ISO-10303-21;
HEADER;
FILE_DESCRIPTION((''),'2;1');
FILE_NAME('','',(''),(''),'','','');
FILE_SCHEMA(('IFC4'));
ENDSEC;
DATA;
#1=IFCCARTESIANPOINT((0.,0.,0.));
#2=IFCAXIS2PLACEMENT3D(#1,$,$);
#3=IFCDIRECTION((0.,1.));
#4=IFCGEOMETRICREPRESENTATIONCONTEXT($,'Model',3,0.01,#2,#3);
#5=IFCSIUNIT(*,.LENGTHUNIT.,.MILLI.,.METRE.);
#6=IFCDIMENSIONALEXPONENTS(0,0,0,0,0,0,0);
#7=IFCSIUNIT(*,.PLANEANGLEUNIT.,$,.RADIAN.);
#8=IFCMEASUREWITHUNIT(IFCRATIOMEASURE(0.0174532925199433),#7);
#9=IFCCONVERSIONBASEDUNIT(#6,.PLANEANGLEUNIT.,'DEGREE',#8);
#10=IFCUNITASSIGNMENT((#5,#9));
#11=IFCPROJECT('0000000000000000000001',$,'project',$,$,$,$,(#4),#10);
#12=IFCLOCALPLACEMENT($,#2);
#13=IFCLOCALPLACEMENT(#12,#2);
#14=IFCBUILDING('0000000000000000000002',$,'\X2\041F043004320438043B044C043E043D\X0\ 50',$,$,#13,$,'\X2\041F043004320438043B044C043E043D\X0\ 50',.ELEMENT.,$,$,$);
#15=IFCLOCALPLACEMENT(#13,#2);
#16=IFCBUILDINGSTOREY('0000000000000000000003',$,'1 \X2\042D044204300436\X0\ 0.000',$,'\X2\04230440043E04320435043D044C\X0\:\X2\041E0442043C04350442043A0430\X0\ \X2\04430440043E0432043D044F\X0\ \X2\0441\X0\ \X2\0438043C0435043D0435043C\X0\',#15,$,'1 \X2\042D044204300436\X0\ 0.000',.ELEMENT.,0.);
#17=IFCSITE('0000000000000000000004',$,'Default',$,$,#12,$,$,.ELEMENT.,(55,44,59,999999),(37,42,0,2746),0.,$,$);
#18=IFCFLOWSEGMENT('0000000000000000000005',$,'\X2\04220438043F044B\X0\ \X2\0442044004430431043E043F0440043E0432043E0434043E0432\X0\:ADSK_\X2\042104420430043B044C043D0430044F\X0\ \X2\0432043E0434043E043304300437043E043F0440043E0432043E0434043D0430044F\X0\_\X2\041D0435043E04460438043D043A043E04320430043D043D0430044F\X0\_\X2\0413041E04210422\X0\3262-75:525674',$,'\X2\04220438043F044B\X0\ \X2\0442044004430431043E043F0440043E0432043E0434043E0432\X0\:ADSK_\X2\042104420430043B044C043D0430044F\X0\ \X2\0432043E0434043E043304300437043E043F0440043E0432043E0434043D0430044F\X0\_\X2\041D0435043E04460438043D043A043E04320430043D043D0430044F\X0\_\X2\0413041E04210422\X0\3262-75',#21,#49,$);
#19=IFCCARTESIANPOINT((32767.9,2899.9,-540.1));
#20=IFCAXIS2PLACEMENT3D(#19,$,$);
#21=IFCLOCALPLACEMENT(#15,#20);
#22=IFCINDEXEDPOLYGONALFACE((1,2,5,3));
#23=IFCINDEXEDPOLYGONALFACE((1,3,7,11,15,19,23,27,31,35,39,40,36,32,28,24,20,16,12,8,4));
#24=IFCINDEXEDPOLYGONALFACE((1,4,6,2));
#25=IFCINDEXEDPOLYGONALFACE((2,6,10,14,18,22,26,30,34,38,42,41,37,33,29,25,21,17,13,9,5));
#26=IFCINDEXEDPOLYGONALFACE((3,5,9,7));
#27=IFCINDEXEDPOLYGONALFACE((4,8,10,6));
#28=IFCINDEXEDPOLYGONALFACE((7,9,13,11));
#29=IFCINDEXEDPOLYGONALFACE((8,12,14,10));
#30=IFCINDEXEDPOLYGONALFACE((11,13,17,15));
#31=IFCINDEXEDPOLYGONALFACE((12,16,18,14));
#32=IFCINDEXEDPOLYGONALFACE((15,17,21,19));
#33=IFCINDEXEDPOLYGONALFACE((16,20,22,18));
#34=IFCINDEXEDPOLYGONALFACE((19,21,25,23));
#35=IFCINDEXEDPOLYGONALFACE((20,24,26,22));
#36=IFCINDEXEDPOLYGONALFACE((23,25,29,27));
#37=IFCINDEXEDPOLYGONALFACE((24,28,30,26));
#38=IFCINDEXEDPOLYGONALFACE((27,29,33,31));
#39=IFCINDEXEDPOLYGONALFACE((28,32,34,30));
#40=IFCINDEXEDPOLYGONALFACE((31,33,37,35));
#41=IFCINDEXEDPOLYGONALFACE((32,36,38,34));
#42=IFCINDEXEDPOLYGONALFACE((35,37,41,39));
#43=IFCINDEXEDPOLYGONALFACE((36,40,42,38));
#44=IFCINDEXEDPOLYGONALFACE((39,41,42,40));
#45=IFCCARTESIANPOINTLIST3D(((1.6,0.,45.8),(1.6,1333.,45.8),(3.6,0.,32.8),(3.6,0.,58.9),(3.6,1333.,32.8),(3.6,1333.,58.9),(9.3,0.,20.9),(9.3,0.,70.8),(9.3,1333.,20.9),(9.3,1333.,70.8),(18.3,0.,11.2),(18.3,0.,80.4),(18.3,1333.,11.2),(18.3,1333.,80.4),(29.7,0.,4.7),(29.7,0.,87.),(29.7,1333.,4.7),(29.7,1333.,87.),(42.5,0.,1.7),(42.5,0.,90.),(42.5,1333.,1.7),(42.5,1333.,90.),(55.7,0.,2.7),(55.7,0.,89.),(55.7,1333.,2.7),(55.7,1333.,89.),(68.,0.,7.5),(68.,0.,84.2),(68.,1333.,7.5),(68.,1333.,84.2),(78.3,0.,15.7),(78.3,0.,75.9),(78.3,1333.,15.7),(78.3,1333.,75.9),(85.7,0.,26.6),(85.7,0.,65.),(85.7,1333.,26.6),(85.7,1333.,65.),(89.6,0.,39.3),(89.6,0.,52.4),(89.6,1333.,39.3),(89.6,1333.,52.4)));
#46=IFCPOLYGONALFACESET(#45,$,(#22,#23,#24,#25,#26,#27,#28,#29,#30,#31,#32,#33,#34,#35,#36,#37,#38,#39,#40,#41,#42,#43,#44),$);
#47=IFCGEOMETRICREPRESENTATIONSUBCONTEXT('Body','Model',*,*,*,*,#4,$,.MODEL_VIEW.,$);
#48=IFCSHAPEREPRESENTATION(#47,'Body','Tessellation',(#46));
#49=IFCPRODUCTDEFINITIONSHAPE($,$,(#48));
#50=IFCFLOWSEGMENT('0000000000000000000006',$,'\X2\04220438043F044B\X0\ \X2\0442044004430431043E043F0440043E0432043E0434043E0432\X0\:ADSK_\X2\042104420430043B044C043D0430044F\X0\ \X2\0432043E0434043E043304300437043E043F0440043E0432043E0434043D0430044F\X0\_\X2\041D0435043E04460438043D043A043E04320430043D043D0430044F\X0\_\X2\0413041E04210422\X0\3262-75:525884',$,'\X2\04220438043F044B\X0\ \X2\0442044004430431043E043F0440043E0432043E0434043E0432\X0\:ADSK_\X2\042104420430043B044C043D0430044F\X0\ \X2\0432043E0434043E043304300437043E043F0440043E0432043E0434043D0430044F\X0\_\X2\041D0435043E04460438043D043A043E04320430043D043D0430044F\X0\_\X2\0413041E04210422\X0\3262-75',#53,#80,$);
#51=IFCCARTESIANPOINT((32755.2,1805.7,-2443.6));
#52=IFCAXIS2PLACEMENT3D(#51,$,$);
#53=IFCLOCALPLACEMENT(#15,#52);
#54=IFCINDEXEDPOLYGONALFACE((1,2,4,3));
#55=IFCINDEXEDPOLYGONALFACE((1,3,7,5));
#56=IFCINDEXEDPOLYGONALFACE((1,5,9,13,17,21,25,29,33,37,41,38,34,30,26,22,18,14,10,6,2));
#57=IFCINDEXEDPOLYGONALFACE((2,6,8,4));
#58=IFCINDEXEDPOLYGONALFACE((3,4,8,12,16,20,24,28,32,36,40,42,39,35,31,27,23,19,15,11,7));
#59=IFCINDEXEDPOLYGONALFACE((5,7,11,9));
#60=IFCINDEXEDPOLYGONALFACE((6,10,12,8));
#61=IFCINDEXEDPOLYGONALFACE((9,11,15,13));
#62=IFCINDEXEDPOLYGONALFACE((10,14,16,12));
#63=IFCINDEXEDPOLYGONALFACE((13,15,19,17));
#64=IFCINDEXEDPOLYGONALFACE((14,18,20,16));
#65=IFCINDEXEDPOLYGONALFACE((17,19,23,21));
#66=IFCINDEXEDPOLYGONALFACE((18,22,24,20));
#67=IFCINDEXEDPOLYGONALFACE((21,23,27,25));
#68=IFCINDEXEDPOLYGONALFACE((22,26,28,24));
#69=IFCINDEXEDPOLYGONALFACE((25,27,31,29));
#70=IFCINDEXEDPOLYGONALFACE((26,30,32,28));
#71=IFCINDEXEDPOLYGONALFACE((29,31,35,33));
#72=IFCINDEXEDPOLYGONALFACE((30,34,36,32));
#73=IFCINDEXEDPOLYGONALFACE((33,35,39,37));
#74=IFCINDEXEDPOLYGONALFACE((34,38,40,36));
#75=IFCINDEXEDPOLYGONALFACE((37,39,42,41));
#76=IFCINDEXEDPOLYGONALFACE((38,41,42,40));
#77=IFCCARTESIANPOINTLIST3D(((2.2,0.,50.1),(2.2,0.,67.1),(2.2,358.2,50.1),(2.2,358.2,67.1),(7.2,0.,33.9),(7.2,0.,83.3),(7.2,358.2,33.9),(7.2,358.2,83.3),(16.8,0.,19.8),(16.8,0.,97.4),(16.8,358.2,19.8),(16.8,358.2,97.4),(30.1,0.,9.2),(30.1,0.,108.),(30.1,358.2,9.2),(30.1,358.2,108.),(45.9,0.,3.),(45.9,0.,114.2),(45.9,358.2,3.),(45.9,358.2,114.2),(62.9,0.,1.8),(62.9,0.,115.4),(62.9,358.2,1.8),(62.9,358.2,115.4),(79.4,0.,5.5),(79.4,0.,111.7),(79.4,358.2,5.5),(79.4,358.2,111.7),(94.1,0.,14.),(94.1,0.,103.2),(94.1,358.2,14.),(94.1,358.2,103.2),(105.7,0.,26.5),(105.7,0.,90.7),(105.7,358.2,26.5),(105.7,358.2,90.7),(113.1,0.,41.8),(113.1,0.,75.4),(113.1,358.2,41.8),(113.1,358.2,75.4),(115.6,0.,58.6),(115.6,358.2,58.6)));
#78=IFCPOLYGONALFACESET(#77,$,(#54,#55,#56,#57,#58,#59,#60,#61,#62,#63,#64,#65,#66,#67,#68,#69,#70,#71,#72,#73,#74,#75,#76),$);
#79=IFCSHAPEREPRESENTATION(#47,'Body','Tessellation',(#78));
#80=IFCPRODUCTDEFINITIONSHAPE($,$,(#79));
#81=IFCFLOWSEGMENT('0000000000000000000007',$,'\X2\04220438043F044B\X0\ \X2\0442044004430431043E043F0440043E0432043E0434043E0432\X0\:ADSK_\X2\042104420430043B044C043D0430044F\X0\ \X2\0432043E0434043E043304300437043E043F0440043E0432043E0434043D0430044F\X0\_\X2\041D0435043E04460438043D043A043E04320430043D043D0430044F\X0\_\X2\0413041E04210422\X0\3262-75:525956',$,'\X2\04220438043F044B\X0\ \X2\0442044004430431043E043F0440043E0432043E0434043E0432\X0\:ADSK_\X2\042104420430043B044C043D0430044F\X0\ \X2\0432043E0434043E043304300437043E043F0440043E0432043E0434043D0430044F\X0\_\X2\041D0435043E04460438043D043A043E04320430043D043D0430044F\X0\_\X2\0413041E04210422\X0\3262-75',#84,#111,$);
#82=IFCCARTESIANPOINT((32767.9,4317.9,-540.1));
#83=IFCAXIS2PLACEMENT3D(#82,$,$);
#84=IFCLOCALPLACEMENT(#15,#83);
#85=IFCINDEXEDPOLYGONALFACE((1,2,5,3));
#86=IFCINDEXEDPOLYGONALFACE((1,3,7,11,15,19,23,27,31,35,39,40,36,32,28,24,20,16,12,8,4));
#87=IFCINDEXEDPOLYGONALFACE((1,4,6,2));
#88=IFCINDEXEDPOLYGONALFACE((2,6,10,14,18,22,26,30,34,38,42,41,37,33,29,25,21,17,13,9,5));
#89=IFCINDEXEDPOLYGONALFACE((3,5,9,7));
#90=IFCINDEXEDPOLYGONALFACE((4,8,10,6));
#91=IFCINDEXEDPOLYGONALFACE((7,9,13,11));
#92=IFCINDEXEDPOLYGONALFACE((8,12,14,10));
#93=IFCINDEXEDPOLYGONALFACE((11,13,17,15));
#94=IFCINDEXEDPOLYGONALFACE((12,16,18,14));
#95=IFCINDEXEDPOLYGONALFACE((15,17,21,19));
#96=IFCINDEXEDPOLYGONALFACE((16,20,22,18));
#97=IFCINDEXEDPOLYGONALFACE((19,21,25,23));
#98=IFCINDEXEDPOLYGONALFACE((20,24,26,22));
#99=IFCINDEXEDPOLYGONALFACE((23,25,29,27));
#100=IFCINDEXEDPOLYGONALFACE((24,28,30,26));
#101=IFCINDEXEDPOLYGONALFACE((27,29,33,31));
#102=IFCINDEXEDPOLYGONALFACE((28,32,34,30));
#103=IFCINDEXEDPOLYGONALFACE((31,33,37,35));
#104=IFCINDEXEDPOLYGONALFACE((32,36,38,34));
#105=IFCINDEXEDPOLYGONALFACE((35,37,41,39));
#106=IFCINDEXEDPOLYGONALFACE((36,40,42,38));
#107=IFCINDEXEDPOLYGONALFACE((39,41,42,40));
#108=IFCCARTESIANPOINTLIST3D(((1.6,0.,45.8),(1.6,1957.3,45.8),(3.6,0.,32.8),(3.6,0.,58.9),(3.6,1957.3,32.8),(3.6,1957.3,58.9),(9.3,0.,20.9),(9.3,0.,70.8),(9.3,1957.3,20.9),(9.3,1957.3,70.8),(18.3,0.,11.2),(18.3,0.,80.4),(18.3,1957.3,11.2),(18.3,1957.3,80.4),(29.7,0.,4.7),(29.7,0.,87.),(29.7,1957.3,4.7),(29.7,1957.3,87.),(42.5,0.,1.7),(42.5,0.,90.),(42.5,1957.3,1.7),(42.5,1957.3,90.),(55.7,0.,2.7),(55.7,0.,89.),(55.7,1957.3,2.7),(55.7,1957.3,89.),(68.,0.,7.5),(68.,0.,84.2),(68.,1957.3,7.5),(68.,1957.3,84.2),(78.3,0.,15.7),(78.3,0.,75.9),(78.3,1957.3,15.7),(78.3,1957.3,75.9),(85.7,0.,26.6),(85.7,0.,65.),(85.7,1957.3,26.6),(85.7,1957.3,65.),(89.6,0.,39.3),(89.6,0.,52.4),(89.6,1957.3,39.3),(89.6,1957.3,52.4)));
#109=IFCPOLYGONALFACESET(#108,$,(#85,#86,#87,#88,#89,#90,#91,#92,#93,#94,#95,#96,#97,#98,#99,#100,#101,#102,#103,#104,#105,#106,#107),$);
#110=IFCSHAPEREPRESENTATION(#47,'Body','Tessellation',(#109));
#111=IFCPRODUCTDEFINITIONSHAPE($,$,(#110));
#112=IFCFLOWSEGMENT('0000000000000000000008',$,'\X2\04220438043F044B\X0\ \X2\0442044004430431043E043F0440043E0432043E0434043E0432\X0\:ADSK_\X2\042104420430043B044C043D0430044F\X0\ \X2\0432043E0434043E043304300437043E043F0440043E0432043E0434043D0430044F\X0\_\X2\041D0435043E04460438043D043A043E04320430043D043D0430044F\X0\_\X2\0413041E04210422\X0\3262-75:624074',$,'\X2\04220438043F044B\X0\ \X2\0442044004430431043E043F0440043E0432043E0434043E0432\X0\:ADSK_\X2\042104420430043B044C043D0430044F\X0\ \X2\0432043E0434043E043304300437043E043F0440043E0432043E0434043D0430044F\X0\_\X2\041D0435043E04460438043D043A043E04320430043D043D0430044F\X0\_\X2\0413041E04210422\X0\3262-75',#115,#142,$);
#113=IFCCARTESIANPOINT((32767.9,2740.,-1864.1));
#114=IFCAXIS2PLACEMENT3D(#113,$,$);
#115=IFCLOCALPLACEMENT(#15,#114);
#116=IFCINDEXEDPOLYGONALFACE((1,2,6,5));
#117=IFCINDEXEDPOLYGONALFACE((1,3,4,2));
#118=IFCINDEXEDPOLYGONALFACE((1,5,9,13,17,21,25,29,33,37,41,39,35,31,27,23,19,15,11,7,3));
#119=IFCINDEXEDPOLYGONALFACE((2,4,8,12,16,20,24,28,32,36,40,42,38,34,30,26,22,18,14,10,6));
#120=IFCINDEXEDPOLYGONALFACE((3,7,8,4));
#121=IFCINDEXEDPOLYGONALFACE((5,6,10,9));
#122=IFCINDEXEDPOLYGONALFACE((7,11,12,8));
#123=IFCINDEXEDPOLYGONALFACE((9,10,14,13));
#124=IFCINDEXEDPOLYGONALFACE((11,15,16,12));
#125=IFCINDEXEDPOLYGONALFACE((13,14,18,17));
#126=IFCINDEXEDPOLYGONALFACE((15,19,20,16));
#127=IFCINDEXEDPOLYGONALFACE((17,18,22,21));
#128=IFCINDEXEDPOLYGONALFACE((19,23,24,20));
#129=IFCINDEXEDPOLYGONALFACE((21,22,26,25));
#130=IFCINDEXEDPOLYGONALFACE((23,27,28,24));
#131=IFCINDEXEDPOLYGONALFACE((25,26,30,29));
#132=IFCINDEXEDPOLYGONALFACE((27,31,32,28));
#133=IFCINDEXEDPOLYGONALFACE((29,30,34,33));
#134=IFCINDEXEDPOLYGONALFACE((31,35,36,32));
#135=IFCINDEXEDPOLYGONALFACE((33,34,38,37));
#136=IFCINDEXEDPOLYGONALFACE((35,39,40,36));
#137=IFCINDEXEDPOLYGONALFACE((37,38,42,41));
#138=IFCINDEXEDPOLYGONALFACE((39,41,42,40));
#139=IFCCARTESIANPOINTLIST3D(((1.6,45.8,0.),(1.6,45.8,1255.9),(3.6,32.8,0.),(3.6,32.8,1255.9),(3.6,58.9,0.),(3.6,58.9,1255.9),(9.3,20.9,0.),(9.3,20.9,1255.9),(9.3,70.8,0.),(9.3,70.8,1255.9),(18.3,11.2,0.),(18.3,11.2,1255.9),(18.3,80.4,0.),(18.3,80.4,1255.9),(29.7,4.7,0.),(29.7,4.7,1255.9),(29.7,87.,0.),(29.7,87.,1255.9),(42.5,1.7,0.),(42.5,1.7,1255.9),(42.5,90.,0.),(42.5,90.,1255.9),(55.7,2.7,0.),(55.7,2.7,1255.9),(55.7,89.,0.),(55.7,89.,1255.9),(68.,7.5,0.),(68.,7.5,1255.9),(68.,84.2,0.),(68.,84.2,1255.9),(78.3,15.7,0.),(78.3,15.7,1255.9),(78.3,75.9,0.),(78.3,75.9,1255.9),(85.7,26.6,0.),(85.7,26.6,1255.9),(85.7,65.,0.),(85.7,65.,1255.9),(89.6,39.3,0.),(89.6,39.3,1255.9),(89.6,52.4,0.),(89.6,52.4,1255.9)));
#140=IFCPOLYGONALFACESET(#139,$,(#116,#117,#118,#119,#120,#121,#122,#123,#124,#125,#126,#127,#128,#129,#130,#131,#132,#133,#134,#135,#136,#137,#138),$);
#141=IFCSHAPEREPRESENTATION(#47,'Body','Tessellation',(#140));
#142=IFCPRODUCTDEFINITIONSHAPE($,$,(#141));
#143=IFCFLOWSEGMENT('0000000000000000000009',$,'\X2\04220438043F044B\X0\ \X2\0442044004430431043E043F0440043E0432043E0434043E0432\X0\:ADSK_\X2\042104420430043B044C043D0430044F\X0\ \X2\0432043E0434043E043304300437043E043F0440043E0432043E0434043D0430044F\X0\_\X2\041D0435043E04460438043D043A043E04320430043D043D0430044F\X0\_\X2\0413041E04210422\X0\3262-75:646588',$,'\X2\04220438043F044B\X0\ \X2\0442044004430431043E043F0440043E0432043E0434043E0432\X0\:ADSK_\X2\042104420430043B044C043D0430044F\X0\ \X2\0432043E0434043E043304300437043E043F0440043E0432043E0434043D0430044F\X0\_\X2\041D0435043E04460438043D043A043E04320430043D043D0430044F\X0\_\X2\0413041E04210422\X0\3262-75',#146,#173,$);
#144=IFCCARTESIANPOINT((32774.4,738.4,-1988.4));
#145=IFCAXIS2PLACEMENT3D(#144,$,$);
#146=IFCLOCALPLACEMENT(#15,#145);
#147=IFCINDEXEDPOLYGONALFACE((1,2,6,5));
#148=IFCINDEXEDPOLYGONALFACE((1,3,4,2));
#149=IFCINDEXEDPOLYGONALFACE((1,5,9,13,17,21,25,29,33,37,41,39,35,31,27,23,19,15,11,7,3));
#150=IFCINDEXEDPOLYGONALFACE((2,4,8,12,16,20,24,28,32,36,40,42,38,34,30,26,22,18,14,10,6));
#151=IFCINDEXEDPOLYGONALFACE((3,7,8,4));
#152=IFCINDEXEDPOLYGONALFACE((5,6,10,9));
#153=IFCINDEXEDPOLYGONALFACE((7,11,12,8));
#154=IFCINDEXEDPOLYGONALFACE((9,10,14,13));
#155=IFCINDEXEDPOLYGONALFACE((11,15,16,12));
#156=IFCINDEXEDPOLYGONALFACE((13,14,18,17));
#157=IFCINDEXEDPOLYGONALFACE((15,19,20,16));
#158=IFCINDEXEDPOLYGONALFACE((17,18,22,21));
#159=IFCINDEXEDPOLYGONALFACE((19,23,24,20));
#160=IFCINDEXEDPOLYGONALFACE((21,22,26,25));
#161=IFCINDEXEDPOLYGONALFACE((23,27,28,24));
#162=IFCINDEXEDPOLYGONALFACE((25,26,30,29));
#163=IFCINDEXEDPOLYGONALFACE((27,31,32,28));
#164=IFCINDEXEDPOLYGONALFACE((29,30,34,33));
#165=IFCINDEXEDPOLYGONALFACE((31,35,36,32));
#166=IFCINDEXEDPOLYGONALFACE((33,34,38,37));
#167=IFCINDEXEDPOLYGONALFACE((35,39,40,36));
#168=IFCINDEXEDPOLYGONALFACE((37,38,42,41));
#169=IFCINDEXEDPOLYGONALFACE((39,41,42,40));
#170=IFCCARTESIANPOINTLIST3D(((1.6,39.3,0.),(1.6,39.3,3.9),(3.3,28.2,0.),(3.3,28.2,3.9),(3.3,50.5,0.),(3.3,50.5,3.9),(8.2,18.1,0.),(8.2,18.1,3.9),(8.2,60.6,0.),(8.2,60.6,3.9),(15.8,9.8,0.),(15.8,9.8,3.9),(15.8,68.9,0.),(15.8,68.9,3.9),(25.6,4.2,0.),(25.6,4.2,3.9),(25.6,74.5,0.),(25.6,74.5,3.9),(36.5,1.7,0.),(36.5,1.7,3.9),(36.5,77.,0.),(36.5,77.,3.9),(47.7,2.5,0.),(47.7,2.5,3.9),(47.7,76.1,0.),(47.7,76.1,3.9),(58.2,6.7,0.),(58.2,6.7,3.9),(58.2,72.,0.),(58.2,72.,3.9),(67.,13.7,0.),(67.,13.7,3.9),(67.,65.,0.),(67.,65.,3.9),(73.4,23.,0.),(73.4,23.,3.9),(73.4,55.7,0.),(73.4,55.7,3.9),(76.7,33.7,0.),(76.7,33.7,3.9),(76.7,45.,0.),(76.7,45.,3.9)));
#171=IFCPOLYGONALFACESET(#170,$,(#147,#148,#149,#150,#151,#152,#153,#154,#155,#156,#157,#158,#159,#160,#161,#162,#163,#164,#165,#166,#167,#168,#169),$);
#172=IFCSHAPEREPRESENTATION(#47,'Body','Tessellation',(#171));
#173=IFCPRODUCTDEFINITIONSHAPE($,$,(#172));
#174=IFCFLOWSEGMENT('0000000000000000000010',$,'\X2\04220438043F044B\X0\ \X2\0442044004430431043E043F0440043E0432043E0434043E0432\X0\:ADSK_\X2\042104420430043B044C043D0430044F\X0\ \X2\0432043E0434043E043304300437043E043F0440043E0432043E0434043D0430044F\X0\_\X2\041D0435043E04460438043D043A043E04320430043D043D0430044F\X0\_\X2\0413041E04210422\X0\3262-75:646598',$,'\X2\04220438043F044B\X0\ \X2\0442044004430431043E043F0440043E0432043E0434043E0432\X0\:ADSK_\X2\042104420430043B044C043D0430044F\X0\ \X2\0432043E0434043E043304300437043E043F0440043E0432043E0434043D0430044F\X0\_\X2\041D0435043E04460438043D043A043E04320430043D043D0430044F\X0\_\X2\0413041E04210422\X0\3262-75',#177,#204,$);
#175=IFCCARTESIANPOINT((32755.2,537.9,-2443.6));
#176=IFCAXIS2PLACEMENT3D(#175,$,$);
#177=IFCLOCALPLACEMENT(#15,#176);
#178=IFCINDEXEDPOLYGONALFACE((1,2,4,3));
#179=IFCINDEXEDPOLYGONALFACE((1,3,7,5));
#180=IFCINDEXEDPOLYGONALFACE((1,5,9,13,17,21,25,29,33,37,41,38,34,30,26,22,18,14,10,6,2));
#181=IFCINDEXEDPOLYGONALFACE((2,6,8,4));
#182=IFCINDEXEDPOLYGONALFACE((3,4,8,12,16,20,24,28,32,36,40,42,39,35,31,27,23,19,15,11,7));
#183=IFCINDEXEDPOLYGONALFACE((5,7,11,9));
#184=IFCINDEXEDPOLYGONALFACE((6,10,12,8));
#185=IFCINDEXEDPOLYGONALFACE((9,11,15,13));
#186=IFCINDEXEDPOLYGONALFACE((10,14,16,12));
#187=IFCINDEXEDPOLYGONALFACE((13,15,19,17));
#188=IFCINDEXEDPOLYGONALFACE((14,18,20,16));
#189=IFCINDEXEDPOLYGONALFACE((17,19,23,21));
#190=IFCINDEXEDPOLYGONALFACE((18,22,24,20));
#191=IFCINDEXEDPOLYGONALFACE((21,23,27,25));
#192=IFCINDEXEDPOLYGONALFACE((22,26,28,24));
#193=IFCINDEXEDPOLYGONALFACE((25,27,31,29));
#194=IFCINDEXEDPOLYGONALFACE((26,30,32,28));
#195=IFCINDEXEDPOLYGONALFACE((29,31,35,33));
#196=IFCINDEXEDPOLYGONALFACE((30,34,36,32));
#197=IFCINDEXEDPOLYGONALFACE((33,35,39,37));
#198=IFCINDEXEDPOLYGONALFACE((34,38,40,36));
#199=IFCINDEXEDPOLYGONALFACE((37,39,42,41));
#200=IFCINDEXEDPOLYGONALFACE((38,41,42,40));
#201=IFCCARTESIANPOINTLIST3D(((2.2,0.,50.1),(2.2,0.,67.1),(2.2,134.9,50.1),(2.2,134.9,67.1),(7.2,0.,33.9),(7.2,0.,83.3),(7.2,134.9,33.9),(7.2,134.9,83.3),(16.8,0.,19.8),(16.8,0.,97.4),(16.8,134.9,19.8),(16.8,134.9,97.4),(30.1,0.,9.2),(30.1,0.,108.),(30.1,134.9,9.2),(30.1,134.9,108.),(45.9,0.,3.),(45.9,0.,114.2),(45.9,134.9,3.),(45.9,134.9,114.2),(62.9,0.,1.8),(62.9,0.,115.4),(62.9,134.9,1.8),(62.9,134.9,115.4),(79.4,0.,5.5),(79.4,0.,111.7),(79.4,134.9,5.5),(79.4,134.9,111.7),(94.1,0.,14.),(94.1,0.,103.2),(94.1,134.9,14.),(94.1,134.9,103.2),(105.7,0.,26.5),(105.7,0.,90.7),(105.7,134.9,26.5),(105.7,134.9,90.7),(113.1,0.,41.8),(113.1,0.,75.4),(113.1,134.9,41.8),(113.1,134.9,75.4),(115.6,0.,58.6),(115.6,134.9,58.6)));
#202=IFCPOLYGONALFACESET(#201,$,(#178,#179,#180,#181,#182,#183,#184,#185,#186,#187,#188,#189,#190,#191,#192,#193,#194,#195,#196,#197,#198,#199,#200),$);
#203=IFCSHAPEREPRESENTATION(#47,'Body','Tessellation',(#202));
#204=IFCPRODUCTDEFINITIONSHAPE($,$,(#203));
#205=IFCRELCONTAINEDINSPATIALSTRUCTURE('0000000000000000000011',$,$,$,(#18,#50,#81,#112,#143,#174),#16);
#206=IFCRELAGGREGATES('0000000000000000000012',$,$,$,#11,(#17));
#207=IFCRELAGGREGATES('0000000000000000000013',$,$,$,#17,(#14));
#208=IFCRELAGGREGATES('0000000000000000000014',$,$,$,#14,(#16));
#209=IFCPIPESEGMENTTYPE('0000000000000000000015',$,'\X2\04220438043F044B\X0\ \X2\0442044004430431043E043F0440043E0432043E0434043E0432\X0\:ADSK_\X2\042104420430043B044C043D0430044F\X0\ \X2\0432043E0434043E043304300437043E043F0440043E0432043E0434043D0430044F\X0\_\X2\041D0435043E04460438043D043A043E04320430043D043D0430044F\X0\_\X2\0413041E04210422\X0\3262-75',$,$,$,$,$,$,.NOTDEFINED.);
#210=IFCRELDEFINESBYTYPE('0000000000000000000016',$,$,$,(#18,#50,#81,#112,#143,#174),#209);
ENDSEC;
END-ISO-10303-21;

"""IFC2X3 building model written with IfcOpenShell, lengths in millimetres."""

from ifc_helpers import new_model, entity, si_unit, converted_unit, direction, frame, frame_2d, origin, origin_2d_with_axis, place, context, subcontext, project, spatial, circle, extrude, type_object, element, save


model = new_model("IFC2X3")

# Units and contexts
model_context = context("Model", 3, precision=0.01, world=origin(), true_north=direction((0.0, 1.0)))
body_context = subcontext(model_context, "Body", "Model", "MODEL_VIEW")
ifc_project = project(units=[si_unit("LENGTHUNIT", "METRE", prefix="MILLI"), converted_unit("PLANEANGLEUNIT", "DEGREE", entity("IfcRatioMeasure", 0.0174532925199433), si_unit("PLANEANGLEUNIT", "RADIAN"), dimensions=[0, 0, 0, 0, 0, 0, 0])], contexts=[model_context])

# Site, building, storey
site_placement = place(None, origin())
site = spatial("IfcSite", under=ifc_project, at=site_placement, Name="Default", CompositionType="ELEMENT", RefLatitude=(55, 44, 59, 999999), RefLongitude=(37, 42, 0, 2746), RefElevation=0.0)
building_placement = place(site_placement, origin())
building = spatial("IfcBuilding", under=site, at=building_placement, Name="Павильон 50", LongName="Павильон 50", CompositionType="ELEMENT")
storey_placement = place(building_placement, origin())
storey = spatial("IfcBuildingStorey", under=building, at=storey_placement, Name="1 Этаж 0.000", ObjectType="Уровень:Отметка уровня с именем", LongName="1 Этаж 0.000", CompositionType="ELEMENT", Elevation=0.0)

# Flow segments
pipe_segment_type = type_object("IfcPipeSegmentType", Name="Типы трубопроводов:ADSK_Стальная водогазопроводная_Неоцинкованная_ГОСТ3262-75", PredefinedType="NOTDEFINED")
flow_segment_1_placement = place(storey_placement, frame((32767.9, 2899.9, -540.1)))
element("IfcFlowSegment", 1, at=flow_segment_1_placement, inside=storey, type_object=pipe_segment_type, Name="Типы трубопроводов:ADSK_Стальная водогазопроводная_Неоцинкованная_ГОСТ3262-75:525674", ObjectType="Типы трубопроводов:ADSK_Стальная водогазопроводная_Неоцинкованная_ГОСТ3262-75", context=body_context, shape_type="SweptSolid", body=[
    extrude(circle(Radius=44.2, at=frame_2d((0.0, 0.0), x_axis=(1.0, 0.0))), frame((45.8, 0.0, 45.8), z_axis=(0.0, 1.0, 0.0), x_axis=(-1.0, 0.0, 0.0)), (0.0, 0.0, 1.0), 1333.0),
])
flow_segment_2_placement = place(storey_placement, frame((32755.2, 1805.7, -2443.6)))
element("IfcFlowSegment", 2, at=flow_segment_2_placement, inside=storey, type_object=pipe_segment_type, Name="Типы трубопроводов:ADSK_Стальная водогазопроводная_Неоцинкованная_ГОСТ3262-75:525884", ObjectType="Типы трубопроводов:ADSK_Стальная водогазопроводная_Неоцинкованная_ГОСТ3262-75", context=body_context, shape_type="SweptSolid", body=[
    extrude(circle(Radius=57.0, at=frame_2d((0.0, 0.0), x_axis=(1.0, 0.0))), frame((58.6, 0.0, 58.6), z_axis=(0.0, 1.0, 0.0), x_axis=(1.0, 0.0, 0.0)), (0.0, 0.0, 1.0), 358.2),
])
flow_segment_3_placement = place(storey_placement, frame((32767.9, 4317.9, -540.1)))
element("IfcFlowSegment", 3, at=flow_segment_3_placement, inside=storey, type_object=pipe_segment_type, Name="Типы трубопроводов:ADSK_Стальная водогазопроводная_Неоцинкованная_ГОСТ3262-75:525956", ObjectType="Типы трубопроводов:ADSK_Стальная водогазопроводная_Неоцинкованная_ГОСТ3262-75", context=body_context, shape_type="SweptSolid", body=[
    extrude(circle(Radius=44.2, at=origin_2d_with_axis()), frame((45.8, 0.0, 45.8), z_axis=(0.0, 1.0, 0.0), x_axis=(-1.0, 0.0, 0.0)), (0.0, 0.0, 1.0), 1957.3),
])
flow_segment_4_placement = place(storey_placement, frame((32767.9, 2740.0, -1864.1)))
element("IfcFlowSegment", 4, at=flow_segment_4_placement, inside=storey, type_object=pipe_segment_type, Name="Типы трубопроводов:ADSK_Стальная водогазопроводная_Неоцинкованная_ГОСТ3262-75:624074", ObjectType="Типы трубопроводов:ADSK_Стальная водогазопроводная_Неоцинкованная_ГОСТ3262-75", context=body_context, shape_type="SweptSolid", body=[
    extrude(circle(Radius=44.2, at=origin_2d_with_axis()), frame((45.8, 45.8, 0.0), z_axis=(0.0, 0.0, 1.0), x_axis=(-1.0, 0.0, 0.0)), (0.0, 0.0, 1.0), 1255.9),
])
flow_segment_5_placement = place(storey_placement, frame((32774.4, 738.4, -1988.4)))
element("IfcFlowSegment", 5, at=flow_segment_5_placement, inside=storey, type_object=pipe_segment_type, Name="Типы трубопроводов:ADSK_Стальная водогазопроводная_Неоцинкованная_ГОСТ3262-75:646588", ObjectType="Типы трубопроводов:ADSK_Стальная водогазопроводная_Неоцинкованная_ГОСТ3262-75", context=body_context, shape_type="SweptSolid", body=[
    extrude(circle(Radius=37.8, at=origin_2d_with_axis()), frame((39.3, 39.3, 0.0), z_axis=(0.0, 0.0, 1.0), x_axis=(-1.0, 0.0, 0.0)), (0.0, 0.0, 1.0), 3.9),
])
flow_segment_6_placement = place(storey_placement, frame((32755.2, 537.9, -2443.6)))
element("IfcFlowSegment", 6, at=flow_segment_6_placement, inside=storey, type_object=pipe_segment_type, Name="Типы трубопроводов:ADSK_Стальная водогазопроводная_Неоцинкованная_ГОСТ3262-75:646598", ObjectType="Типы трубопроводов:ADSK_Стальная водогазопроводная_Неоцинкованная_ГОСТ3262-75", context=body_context, shape_type="SweptSolid", body=[
    extrude(circle(Radius=57.0, at=frame_2d((0.0, 0.0), x_axis=(1.0, 0.0))), frame((58.6, 0.0, 58.6), z_axis=(0.0, 1.0, 0.0), x_axis=(1.0, 0.0, 0.0)), (0.0, 0.0, 1.0), 134.9),
])

save(model, "model.ifc")
